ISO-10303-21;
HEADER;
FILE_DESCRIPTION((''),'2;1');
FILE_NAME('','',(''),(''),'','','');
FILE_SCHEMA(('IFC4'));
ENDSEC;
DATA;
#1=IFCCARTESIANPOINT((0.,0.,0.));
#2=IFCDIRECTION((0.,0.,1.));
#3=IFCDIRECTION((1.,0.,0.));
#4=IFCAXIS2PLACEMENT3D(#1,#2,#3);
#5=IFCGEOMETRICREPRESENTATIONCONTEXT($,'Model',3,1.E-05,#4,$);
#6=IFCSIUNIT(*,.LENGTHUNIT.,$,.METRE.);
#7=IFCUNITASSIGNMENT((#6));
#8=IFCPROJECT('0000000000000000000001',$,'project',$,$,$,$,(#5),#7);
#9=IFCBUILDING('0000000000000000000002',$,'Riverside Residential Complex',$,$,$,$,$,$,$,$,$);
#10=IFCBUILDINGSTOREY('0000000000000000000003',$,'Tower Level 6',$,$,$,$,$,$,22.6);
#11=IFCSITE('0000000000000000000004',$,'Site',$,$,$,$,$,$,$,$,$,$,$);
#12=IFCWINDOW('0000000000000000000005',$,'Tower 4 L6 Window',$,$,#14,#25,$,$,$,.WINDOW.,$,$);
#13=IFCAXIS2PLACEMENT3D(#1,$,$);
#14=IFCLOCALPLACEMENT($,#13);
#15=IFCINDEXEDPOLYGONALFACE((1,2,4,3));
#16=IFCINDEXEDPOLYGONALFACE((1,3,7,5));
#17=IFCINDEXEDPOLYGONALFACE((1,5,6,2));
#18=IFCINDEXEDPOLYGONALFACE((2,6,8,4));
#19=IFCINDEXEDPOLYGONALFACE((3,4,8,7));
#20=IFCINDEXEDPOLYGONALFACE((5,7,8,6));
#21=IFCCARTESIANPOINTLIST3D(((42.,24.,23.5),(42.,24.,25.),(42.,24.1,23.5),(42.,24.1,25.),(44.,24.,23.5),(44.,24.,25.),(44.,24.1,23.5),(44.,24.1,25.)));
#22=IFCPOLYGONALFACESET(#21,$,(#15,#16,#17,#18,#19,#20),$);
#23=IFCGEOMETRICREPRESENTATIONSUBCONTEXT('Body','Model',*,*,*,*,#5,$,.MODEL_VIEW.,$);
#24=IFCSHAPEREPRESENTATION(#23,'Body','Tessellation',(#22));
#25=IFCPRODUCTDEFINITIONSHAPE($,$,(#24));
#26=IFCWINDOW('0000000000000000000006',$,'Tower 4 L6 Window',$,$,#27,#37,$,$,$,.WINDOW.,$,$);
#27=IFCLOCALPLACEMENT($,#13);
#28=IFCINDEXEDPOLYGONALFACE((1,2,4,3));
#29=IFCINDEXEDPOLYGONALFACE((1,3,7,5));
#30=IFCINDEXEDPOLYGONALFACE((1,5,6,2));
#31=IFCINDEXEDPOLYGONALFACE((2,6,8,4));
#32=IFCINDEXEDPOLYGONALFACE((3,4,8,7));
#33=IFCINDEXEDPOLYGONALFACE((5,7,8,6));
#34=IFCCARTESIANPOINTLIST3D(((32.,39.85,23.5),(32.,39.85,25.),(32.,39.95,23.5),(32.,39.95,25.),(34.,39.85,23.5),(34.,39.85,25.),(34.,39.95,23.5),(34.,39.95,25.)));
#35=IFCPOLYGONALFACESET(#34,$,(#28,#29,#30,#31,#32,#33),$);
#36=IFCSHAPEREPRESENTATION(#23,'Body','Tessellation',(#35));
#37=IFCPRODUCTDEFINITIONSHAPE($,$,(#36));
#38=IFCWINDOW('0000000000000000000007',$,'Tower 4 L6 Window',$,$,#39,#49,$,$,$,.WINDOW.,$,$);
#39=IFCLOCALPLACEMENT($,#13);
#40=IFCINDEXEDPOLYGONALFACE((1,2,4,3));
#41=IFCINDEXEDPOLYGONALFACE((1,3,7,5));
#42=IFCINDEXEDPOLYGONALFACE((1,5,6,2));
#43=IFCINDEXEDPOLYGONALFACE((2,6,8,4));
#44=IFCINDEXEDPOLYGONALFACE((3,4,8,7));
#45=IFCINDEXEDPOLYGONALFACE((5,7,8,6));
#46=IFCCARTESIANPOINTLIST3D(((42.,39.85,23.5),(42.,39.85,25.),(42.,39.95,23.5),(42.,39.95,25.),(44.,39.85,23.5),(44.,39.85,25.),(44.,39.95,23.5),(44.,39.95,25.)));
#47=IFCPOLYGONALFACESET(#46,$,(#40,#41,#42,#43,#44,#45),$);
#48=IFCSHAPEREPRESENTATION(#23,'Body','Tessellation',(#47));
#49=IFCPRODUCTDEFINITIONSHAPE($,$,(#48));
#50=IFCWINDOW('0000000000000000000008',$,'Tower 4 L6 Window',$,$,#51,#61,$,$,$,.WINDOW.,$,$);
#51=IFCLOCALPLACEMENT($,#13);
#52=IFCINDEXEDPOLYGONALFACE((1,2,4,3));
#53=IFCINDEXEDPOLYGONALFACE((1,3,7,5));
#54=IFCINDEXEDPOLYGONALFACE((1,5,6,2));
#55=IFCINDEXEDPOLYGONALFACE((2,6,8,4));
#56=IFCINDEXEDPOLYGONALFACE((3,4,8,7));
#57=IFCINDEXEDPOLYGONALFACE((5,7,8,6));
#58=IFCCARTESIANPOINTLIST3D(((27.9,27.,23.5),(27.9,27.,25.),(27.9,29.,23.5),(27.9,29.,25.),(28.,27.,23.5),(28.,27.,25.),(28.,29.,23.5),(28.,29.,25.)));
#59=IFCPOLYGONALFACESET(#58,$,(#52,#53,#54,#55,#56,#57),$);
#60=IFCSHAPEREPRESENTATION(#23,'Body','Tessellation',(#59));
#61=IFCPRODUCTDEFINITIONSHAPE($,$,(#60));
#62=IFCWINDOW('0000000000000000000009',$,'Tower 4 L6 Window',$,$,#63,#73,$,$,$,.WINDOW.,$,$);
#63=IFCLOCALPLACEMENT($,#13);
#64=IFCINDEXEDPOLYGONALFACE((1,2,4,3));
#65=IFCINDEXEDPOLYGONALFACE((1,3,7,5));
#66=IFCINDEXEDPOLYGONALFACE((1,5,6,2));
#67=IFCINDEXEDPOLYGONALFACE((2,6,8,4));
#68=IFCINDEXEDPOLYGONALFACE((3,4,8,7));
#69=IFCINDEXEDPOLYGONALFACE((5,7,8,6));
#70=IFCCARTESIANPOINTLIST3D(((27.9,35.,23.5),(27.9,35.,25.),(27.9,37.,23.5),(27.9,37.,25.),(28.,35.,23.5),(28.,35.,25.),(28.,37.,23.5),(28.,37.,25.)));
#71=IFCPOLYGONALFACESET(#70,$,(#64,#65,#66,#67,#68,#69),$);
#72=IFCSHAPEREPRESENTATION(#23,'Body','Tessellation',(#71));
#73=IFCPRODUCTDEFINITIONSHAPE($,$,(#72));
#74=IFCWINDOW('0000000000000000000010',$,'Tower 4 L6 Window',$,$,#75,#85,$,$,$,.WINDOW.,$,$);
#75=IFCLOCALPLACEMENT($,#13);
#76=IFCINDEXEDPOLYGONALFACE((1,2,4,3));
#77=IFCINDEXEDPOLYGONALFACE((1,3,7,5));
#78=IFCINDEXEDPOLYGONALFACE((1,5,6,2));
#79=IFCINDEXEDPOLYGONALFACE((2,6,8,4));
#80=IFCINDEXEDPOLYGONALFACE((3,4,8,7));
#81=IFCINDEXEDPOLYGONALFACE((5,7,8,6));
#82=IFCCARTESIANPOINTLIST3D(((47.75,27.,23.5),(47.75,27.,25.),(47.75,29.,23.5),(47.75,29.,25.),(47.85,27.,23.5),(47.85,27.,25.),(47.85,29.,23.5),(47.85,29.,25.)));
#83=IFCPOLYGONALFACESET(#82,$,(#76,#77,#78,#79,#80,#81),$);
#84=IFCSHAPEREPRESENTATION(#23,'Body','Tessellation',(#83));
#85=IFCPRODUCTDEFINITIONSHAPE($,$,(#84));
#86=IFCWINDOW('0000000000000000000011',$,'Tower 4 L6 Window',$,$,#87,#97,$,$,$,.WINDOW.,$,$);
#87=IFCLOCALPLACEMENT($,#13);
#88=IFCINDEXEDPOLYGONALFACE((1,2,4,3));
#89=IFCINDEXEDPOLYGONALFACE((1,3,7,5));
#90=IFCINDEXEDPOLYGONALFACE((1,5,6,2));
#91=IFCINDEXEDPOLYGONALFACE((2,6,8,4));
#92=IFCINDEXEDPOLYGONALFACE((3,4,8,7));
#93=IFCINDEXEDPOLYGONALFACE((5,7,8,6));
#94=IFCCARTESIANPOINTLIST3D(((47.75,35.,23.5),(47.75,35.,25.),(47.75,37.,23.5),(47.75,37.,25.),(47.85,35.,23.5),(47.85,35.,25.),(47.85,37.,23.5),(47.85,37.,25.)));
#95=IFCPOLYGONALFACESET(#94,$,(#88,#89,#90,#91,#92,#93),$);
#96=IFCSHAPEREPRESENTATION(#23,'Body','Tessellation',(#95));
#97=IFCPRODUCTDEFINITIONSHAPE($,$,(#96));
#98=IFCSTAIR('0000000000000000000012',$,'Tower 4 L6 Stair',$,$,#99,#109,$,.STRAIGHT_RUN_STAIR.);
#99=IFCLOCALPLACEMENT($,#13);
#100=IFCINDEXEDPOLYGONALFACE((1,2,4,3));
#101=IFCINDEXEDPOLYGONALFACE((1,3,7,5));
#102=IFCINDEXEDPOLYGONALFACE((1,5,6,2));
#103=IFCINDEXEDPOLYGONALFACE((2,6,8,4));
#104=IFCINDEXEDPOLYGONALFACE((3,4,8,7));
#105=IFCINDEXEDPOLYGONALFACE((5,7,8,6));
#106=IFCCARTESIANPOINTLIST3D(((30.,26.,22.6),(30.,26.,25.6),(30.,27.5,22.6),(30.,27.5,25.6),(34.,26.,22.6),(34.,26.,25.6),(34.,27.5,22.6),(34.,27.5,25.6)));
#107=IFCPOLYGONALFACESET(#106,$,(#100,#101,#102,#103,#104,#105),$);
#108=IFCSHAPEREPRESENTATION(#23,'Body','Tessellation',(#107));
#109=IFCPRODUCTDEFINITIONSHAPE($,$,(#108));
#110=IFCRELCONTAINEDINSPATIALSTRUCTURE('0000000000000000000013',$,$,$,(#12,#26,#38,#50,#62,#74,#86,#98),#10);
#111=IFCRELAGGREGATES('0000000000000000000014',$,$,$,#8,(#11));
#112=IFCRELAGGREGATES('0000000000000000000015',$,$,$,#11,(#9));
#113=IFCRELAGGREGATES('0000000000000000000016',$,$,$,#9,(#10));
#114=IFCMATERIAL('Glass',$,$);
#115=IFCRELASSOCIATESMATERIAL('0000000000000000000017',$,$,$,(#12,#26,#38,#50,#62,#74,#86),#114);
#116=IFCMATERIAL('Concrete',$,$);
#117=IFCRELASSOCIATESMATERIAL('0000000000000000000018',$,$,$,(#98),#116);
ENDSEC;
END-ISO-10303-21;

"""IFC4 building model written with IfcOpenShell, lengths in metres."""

from ifc_helpers import new_model, si_unit, frame, origin_with_axes, place, context, subcontext, project, spatial, line, indexed_curve, outline, extrude, material, element, save


model = new_model("IFC4")

# Units and contexts
model_context = context("Model", 3, precision=1e-05, world=origin_with_axes())
body_context = subcontext(model_context, "Body", "Model", "MODEL_VIEW")
ifc_project = project(units=[si_unit("LENGTHUNIT", "METRE")], contexts=[model_context])

# Site, building, storey
site = spatial("IfcSite", under=ifc_project, Name="Site")
building = spatial("IfcBuilding", under=site, Name="Riverside Residential Complex")
storey = spatial("IfcBuildingStorey", under=building, Name="Tower Level 6", Elevation=22.6)

# Shared definitions
ifc_material_1 = material(Name="Concrete")

# Windows
ifc_material_2 = material(Name="Glass")
for number, where, z_axis, x_axis, name in (
    (1, (42.0, 24.0, 23.5), (0.0, 0.0, 1.0), (1.0, 0.0, 0.0), "Tower 4 L6 Window"),
    (2, (32.0, 39.85, 23.5), (0.0, 0.0, 1.0), (1.0, 0.0, 0.0), "Tower 4 L6 Window"),
    (3, (42.0, 39.85, 23.5), (0.0, 0.0, 1.0), (1.0, 0.0, 0.0), "Tower 4 L6 Window"),
    (4, (28.0, 27.0, 23.5), (0.0, 0.0, 1.0), (0.0, 1.0, 0.0), "Tower 4 L6 Window"),
    (5, (28.0, 35.0, 23.5), (0.0, 0.0, 1.0), (0.0, 1.0, 0.0), "Tower 4 L6 Window"),
    (6, (47.85, 27.0, 23.5), (0.0, 0.0, 1.0), (0.0, 1.0, 0.0), "Tower 4 L6 Window"),
    (7, (47.85, 35.0, 23.5), (0.0, 0.0, 1.0), (0.0, 1.0, 0.0), "Tower 4 L6 Window"),
):
    element("IfcWindow", number, at=place(None, frame(where, z_axis=z_axis, x_axis=x_axis)), inside=storey, material=ifc_material_2, Name=name, PredefinedType="WINDOW", context=body_context, shape_type="SweptSolid", body=[
        extrude(outline(indexed_curve([(0.0, 0.0), (2.0, 0.0), (2.0, 0.1), (0.0, 0.1)], segments=[line(1, 2, 3, 4, 1)])), origin_with_axes(), (0.0, 0.0, 1.0), 1.5),
    ])

# Stair
stair_placement = place(None, frame((30.0, 26.0, 22.6), z_axis=(0.0, 0.0, 1.0), x_axis=(1.0, 0.0, 0.0)))
element("IfcStair", 8, at=stair_placement, inside=storey, material=ifc_material_1, Name="Tower 4 L6 Stair", PredefinedType="STRAIGHT_RUN_STAIR", context=body_context, shape_type="SweptSolid", body=[
    extrude(outline(indexed_curve([(0.0, 0.0), (4.0, 0.0), (4.0, 1.5), (0.0, 1.5)], segments=[line(1, 2, 3, 4, 1)])), origin_with_axes(), (0.0, 0.0, 1.0), 3.0),
])

save(model, "model.ifc")
